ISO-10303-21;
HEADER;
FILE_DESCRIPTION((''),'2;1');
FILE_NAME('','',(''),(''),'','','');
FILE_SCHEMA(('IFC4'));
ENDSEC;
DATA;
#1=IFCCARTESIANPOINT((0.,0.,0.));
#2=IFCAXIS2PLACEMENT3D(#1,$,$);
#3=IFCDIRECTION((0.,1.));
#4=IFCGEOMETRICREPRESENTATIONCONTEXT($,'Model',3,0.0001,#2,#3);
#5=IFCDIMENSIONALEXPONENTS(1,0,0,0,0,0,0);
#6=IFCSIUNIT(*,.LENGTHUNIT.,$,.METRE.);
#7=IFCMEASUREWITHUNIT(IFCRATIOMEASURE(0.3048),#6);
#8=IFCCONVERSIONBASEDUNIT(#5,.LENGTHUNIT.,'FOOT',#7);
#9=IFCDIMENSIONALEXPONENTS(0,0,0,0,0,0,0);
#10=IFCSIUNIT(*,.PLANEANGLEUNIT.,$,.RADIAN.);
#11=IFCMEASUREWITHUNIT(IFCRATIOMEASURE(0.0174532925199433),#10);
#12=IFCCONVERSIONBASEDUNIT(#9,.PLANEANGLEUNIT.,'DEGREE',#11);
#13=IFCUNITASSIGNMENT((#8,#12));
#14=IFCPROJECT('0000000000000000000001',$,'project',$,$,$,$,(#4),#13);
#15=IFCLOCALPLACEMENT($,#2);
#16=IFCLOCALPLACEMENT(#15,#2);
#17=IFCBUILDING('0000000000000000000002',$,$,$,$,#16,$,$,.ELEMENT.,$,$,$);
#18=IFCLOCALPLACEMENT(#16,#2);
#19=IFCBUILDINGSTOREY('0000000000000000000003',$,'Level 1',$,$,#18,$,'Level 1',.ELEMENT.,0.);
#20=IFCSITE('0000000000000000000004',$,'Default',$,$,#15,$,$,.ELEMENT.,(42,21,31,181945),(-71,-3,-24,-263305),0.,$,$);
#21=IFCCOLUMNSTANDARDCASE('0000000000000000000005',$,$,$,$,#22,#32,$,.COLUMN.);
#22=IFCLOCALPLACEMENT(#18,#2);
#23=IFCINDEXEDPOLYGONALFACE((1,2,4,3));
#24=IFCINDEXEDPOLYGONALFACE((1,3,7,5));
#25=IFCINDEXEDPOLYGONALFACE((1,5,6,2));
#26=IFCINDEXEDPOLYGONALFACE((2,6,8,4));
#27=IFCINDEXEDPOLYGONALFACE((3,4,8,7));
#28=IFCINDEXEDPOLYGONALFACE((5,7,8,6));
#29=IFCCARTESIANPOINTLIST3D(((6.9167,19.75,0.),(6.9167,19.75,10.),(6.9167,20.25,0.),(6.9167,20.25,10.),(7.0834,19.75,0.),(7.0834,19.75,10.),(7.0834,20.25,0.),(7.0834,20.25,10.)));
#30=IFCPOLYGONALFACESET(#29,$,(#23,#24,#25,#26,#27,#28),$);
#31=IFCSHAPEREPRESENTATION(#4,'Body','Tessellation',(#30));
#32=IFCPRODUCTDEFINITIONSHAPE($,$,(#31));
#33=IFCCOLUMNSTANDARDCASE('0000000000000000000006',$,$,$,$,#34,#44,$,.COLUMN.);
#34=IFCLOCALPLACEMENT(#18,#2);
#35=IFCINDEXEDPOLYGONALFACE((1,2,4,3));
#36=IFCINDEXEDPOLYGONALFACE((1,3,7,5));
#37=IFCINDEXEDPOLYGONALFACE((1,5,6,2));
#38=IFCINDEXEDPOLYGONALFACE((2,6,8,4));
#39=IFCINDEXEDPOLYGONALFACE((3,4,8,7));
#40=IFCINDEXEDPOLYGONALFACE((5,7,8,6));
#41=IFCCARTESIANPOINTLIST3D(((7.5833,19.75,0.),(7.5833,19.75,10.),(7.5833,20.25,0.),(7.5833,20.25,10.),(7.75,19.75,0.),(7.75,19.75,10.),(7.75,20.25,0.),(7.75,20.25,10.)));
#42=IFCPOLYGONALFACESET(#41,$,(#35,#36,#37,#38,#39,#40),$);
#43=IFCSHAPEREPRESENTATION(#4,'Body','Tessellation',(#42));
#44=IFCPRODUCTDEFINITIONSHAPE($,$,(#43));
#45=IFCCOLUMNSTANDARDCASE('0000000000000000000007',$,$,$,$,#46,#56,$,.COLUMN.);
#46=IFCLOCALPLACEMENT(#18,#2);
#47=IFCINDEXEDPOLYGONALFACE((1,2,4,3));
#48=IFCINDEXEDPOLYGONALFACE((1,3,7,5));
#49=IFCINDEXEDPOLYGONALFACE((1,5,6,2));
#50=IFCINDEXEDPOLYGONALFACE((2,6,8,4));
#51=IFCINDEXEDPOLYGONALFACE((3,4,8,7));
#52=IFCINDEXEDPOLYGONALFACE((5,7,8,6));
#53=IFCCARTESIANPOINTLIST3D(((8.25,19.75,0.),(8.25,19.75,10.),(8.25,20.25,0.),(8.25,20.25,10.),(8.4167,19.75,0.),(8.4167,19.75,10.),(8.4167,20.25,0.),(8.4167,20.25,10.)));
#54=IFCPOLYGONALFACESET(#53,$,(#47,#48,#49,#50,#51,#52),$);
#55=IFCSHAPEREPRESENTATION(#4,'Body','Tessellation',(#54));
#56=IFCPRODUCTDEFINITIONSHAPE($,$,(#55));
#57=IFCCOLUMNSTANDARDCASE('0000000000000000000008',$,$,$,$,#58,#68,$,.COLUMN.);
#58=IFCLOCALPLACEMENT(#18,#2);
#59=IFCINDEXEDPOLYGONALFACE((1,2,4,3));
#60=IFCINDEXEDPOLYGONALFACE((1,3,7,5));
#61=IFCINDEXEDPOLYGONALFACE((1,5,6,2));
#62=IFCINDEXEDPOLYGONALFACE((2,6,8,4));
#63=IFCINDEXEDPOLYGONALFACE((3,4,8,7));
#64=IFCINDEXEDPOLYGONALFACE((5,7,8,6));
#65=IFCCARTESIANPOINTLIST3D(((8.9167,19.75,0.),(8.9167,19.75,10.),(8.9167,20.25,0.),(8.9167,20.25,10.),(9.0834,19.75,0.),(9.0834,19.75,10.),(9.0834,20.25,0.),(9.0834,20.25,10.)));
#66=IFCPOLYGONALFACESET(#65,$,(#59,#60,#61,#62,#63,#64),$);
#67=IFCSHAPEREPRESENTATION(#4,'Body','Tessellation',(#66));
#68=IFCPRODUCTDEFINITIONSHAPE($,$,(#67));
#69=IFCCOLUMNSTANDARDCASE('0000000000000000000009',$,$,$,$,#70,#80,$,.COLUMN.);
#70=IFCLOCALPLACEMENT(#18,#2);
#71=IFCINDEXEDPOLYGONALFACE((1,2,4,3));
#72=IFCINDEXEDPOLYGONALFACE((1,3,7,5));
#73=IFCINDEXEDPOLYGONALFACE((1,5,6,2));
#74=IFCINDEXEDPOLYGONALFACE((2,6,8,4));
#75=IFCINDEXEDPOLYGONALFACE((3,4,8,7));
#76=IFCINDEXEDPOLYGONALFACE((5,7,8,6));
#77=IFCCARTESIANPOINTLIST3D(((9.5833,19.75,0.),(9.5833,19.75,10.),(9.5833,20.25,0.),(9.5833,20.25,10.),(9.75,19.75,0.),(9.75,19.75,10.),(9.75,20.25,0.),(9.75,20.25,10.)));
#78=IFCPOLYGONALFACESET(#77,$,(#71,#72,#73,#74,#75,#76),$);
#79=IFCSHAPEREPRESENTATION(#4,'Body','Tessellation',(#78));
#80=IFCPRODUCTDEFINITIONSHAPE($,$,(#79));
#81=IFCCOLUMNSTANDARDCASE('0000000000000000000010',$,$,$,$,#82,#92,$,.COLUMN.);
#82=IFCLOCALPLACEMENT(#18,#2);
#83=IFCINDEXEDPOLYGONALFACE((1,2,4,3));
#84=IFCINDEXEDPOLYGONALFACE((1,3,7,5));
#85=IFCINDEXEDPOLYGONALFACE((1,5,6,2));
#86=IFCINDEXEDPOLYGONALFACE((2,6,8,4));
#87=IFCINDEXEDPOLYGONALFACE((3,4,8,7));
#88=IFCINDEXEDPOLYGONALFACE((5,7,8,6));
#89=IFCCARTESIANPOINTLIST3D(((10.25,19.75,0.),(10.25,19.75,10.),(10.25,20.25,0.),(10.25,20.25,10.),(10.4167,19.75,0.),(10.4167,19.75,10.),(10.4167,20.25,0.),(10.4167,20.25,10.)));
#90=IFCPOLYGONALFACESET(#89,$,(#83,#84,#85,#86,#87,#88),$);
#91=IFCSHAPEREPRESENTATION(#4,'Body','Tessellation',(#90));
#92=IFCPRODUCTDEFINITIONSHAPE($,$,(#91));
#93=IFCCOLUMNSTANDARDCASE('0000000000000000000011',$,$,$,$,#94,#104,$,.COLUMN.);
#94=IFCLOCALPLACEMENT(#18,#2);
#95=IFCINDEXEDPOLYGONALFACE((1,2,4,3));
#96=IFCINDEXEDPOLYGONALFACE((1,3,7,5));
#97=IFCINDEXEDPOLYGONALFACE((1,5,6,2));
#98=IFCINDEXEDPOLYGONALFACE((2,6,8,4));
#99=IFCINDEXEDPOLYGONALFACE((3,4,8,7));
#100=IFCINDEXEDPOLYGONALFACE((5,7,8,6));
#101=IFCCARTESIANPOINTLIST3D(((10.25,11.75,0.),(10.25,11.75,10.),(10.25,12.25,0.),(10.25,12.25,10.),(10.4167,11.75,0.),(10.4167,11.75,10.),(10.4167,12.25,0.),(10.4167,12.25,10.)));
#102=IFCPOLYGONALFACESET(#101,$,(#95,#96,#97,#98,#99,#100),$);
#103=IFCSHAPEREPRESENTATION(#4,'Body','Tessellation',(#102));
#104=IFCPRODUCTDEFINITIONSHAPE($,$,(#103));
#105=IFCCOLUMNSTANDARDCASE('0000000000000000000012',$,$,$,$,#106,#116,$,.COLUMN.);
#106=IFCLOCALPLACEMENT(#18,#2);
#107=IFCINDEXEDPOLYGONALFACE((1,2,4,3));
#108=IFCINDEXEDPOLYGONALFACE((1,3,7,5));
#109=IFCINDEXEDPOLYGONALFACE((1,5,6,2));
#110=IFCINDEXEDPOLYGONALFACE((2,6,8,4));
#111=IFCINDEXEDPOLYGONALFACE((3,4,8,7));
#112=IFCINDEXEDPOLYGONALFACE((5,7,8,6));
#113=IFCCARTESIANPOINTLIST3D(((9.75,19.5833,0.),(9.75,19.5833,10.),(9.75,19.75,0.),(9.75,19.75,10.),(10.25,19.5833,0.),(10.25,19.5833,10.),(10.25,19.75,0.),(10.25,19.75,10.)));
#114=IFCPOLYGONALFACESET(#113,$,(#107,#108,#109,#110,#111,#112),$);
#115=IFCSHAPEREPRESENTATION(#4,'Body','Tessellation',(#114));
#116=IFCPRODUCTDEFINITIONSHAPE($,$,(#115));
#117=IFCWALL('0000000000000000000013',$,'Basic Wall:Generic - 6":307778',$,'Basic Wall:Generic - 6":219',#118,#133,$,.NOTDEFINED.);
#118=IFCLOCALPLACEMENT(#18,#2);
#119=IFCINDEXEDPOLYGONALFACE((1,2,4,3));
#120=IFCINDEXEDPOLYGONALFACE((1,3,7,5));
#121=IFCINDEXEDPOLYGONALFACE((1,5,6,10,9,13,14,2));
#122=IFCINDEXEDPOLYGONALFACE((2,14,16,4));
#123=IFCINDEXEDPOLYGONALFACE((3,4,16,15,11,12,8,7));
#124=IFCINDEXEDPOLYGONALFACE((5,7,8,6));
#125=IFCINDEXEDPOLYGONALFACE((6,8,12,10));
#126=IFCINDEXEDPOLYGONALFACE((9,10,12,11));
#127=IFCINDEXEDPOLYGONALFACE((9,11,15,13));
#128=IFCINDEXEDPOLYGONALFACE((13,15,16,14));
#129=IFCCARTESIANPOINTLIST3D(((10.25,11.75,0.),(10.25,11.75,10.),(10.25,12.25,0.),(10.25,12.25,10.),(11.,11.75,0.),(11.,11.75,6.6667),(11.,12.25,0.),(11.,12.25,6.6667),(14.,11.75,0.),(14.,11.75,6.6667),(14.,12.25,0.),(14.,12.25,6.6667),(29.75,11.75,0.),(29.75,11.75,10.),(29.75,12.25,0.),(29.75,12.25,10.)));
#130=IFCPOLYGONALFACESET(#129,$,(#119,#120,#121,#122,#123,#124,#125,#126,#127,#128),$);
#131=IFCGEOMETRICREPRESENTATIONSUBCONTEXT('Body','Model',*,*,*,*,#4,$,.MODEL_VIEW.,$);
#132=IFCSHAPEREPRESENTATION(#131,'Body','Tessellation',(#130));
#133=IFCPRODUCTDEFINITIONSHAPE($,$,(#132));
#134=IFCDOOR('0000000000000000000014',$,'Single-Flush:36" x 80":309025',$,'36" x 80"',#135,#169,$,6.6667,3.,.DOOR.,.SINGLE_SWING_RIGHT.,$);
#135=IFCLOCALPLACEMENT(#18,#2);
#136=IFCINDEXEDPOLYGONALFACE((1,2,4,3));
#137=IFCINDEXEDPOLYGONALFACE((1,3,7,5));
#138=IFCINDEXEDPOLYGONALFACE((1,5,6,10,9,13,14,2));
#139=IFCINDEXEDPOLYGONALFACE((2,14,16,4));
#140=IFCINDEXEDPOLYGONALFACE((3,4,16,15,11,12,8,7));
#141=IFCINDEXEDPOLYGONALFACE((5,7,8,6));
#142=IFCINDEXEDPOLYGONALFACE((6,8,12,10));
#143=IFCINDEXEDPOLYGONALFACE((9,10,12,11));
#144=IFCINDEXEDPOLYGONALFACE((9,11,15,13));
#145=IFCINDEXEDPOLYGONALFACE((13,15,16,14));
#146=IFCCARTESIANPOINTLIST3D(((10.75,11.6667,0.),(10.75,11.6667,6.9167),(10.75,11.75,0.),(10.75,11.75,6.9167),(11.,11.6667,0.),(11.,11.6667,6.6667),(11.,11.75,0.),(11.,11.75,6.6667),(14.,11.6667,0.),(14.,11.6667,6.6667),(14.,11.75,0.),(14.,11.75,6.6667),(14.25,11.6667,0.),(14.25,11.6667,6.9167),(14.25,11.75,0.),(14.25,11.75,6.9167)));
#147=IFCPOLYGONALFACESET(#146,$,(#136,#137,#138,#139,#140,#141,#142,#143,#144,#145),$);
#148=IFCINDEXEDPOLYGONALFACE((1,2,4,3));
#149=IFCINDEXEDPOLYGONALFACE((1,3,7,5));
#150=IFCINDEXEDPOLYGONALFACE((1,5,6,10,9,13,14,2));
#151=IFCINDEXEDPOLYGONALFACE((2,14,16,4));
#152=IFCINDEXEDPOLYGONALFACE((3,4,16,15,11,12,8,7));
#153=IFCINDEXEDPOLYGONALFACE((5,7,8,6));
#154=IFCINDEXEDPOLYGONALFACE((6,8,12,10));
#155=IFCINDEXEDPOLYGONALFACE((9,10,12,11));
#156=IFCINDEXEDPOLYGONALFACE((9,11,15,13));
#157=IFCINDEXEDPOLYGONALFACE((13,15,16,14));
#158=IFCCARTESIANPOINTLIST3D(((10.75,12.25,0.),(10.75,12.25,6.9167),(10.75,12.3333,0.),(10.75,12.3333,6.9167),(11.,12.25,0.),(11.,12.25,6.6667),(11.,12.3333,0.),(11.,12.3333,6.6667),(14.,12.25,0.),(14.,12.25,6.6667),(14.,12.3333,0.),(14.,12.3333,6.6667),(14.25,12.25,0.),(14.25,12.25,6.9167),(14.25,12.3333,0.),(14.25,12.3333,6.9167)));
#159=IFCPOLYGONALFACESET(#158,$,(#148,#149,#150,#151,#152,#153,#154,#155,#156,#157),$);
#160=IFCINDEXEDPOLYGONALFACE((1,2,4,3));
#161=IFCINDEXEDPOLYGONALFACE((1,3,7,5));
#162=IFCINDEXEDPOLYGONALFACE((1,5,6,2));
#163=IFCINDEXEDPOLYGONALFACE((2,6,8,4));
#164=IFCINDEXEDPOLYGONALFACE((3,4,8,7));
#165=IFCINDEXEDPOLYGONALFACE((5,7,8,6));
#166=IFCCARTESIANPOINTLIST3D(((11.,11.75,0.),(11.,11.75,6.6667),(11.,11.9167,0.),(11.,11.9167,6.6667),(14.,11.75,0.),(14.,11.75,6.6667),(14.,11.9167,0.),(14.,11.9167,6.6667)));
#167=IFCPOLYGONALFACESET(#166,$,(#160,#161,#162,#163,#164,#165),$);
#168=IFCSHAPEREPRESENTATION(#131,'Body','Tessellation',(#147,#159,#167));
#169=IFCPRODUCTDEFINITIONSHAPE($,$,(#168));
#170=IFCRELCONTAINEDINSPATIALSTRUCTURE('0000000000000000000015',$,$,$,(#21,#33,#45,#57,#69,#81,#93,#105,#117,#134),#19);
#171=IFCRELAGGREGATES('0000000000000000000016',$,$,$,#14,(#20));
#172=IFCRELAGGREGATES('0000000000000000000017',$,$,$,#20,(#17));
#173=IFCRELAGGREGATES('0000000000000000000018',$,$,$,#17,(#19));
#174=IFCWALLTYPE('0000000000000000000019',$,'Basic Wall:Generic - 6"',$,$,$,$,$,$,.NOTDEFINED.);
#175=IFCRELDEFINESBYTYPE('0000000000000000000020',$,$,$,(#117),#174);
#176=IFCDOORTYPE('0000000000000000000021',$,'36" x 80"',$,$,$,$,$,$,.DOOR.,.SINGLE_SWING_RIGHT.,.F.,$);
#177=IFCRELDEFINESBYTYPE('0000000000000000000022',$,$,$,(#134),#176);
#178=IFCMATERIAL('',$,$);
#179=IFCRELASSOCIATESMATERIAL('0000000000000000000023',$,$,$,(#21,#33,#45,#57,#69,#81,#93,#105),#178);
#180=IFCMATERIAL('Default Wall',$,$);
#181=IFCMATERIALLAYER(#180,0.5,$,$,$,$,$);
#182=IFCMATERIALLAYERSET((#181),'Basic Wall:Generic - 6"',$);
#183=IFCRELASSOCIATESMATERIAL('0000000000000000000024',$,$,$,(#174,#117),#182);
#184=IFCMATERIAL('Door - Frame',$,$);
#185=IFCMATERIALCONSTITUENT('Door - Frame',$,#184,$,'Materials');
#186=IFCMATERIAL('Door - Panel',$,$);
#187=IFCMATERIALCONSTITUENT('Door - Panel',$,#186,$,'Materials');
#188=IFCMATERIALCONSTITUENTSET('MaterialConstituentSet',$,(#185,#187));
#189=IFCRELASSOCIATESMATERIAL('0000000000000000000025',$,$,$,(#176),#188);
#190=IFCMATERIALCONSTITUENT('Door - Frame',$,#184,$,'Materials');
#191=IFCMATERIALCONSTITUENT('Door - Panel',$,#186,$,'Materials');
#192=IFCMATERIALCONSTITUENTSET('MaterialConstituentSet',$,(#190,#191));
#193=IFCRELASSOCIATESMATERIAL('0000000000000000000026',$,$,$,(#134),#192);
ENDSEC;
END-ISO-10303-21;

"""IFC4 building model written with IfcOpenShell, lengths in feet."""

from ifc_helpers import new_model, entity, si_unit, converted_unit, direction, frame, frame_2d, origin, origin_2d_with_axis, place, context, subcontext, project, spatial, polyline, rectangle, outline, extrude, source, transform, mapped, material, layer, layer_set, layer_usage, constituent, constituent_set, type_object, type_shapes, element, fill, save


model = new_model("IFC4")

# Units and contexts
model_context = context("Model", 3, precision=0.0001, world=origin(), true_north=direction((0.0, 1.0)))
body_context = subcontext(model_context, "Body", "Model", "MODEL_VIEW")
ifc_project = project(units=[converted_unit("LENGTHUNIT", "FOOT", entity("IfcRatioMeasure", 0.3048), si_unit("LENGTHUNIT", "METRE"), dimensions=[1, 0, 0, 0, 0, 0, 0]), converted_unit("PLANEANGLEUNIT", "DEGREE", entity("IfcRatioMeasure", 0.0174532925199433), si_unit("PLANEANGLEUNIT", "RADIAN"), dimensions=[0, 0, 0, 0, 0, 0, 0])], contexts=[model_context])

# Site, building, storey
site_placement = place(None, origin())
site = spatial("IfcSite", under=ifc_project, at=site_placement, Name="Default", CompositionType="ELEMENT", RefLatitude=(42, 21, 31, 181945), RefLongitude=(-71, -3, -24, -263305), RefElevation=0.0)
building_placement = place(site_placement, origin())
building = spatial("IfcBuilding", under=site, at=building_placement, CompositionType="ELEMENT")
storey_placement = place(building_placement, origin())
storey = spatial("IfcBuildingStorey", under=building, at=storey_placement, Name="Level 1", LongName="Level 1", CompositionType="ELEMENT", Elevation=0.0)

# Columns
ifc_material_1 = material(Name="")
placement = place(storey_placement, frame((0.25, 20.0, 0.0)))
for number, where, z_axis, x_axis in (
    (1, (6.75, 0.0, 0.0), (0.0, 0.0, 1.0), (1.0, 0.0, 0.0)),
    (2, (7.4167, 0.0, 0.0), (0.0, 0.0, 1.0), (1.0, 0.0, 0.0)),
    (3, (8.0833, 0.0, 0.0), (0.0, 0.0, 1.0), (1.0, 0.0, 0.0)),
    (4, (8.75, 0.0, 0.0), (0.0, 0.0, 1.0), (1.0, 0.0, 0.0)),
    (5, (9.4167, 0.0, 0.0), (0.0, 0.0, 1.0), (1.0, 0.0, 0.0)),
    (6, (10.0833, 0.0, 0.0), (0.0, 0.0, 1.0), (1.0, 0.0, 0.0)),
):
    element("IfcColumnStandardCase", number, at=place(placement, frame(where, z_axis=z_axis, x_axis=x_axis)), inside=storey, material=ifc_material_1, PredefinedType="COLUMN", context=model_context, shape_type="SweptSolid", body=[
        extrude(rectangle(XDim=0.1667, YDim=0.5), origin(), (0.0, 0.0, 1.0), 10.0),
    ])
wall_1_placement = place(storey_placement, frame((10.25, 12.0, 0.0)))
for number, where, z_axis, x_axis in (
    (7, (0.0833, 0.0, 0.0), (0.0, 0.0, 1.0), (1.0, 0.0, 0.0)),
):
    element("IfcColumnStandardCase", number, at=place(wall_1_placement, frame(where, z_axis=z_axis, x_axis=x_axis)), inside=storey, material=ifc_material_1, PredefinedType="COLUMN", context=model_context, shape_type="SweptSolid", body=[
        extrude(rectangle(XDim=0.1667, YDim=0.5), origin(), (0.0, 0.0, 1.0), 10.0),
    ])
wall_2_placement = place(storey_placement, frame((10.0, 19.75, 0.0), z_axis=(0.0, 0.0, 1.0), x_axis=(0.0, -1.0, 0.0)))
for number, where, z_axis, x_axis in (
    (8, (0.0833, 0.0, 0.0), (0.0, 0.0, 1.0), (1.0, 0.0, 0.0)),
):
    element("IfcColumnStandardCase", number, at=place(wall_2_placement, frame(where, z_axis=z_axis, x_axis=x_axis)), inside=storey, material=ifc_material_1, PredefinedType="COLUMN", context=model_context, shape_type="SweptSolid", body=[
        extrude(rectangle(XDim=0.1667, YDim=0.5), origin(), (0.0, 0.0, 1.0), 10.0),
    ])

# Wall, opening, door
ifc_material_2 = material(Name="Default Wall")
ifc_layer = layer(ifc_material_2, 0.5)
ifc_layer_set = layer_set([ifc_layer], Name="Basic Wall:Generic - 6\"")
ifc_layer_usage_1 = layer_usage(ifc_layer_set, "AXIS2", "NEGATIVE", 0.25)
wall_type = type_object("IfcWallType", Name="Basic Wall:Generic - 6\"", PredefinedType="NOTDEFINED", material=ifc_layer_set)
wall_1 = element("IfcWall", 9, at=wall_1_placement, inside=storey, type_object=wall_type, material=ifc_layer_usage_1, Name="Basic Wall:Generic - 6\":307778", ObjectType="Basic Wall:Generic - 6\":219", PredefinedType="NOTDEFINED", context=body_context, shape_type="SweptSolid", body=[
    extrude(rectangle(XDim=19.5, YDim=0.5, at=frame_2d((9.75, 0.0), x_axis=(-1.0, 0.0))), origin(), (0.0, 0.0, 1.0), 10.0),
])
opening_1_placement = place(wall_1_placement, frame((3.75, 0.25, 0.0)))
opening_1 = element("IfcOpeningElement", 10, at=opening_1_placement, cuts=wall_1, ObjectType="Opening", PredefinedType="OPENING", context=body_context, shape_type="SweptSolid", body=[
    extrude(rectangle(XDim=3.0, YDim=6.6667, at=frame_2d((3.3333, 1.5), x_axis=(0.0, 1.0))), frame((0.0, 0.0, 0.0), z_axis=(0.0, -1.0, 0.0), x_axis=(0.0, 0.0, 1.0)), (0.0, 0.0, 1.0), 0.5),
])
ifc_material_3 = material(Name="Door - Frame")
ifc_constituent_1 = constituent(ifc_material_3, Name="Door - Frame", Category="Materials")
ifc_material_4 = material(Name="Door - Panel")
ifc_constituent_2 = constituent(ifc_material_4, Name="Door - Panel", Category="Materials")
ifc_constituent_set_1 = constituent_set(constituents=[ifc_constituent_1, ifc_constituent_2], Name="MaterialConstituentSet")
ifc_constituent_3 = constituent(ifc_material_3, Name="Door - Frame", Category="Materials")
ifc_constituent_4 = constituent(ifc_material_4, Name="Door - Panel", Category="Materials")
ifc_constituent_set_2 = constituent_set(constituents=[ifc_constituent_3, ifc_constituent_4], Name="MaterialConstituentSet")
door_type = type_object("IfcDoorType", Name="36\" x 80\"", OperationType="SINGLE_SWING_RIGHT", ParameterTakesPrecedence=False, PredefinedType="DOOR", material=ifc_constituent_set_2)
shared_shape = source(origin(), body_context, "Body", "SweptSolid", [
    extrude(outline(polyline([(-1.75, -3.5208), (1.75, -3.5208), (1.75, 3.3958), (1.5, 3.3958), (1.5, -3.2708), (-1.5, -3.2708), (-1.5, 3.3958), (-1.75, 3.3958), (-1.75, -3.5208)])), frame((1.5, 0.5, 3.3958), z_axis=(0.0, 1.0, 0.0), x_axis=(1.0, 0.0, 0.0)), (0.0, 0.0, 1.0), 0.0833),
    extrude(outline(polyline([(-3.5208, -1.75), (3.3958, -1.75), (3.3958, -1.5), (-3.2708, -1.5), (-3.2708, 1.5), (3.3958, 1.5), (3.3958, 1.75), (-3.5208, 1.75), (-3.5208, -1.75)])), frame((1.5, -0.0833, 3.3958), z_axis=(0.0, 1.0, 0.0), x_axis=(0.0, 0.0, -1.0)), (0.0, 0.0, 1.0), 0.0833),
    extrude(rectangle(XDim=0.1667, YDim=3.0, at=origin_2d_with_axis()), frame((1.5, 0.4167, 0.0), z_axis=(0.0, 0.0, 1.0), x_axis=(0.0, 1.0, 0.0)), (0.0, 0.0, 1.0), 6.6667),
])
type_shapes(door_type, [shared_shape])
door_1_placement = place(opening_1_placement, frame((0.0, 0.0, 0.0), z_axis=(0.0, 0.0, 1.0), x_axis=(-1.0, 0.0, 0.0)))
door_1 = element("IfcDoor", 11, at=door_1_placement, inside=storey, type_object=door_type, material=ifc_constituent_set_1, Name="Single-Flush:36\" x 80\":309025", ObjectType="36\" x 80\"", OperationType="SINGLE_SWING_RIGHT", OverallHeight=6.6667, OverallWidth=3.0, PredefinedType="DOOR", context=body_context, shape_type="MappedRepresentation", body=[
    mapped(shared_shape, transform((0.0, 0.0, 0.0), scale=1.0)),
])
fill(opening_1, door_1)

save(model, "model.ifc")
